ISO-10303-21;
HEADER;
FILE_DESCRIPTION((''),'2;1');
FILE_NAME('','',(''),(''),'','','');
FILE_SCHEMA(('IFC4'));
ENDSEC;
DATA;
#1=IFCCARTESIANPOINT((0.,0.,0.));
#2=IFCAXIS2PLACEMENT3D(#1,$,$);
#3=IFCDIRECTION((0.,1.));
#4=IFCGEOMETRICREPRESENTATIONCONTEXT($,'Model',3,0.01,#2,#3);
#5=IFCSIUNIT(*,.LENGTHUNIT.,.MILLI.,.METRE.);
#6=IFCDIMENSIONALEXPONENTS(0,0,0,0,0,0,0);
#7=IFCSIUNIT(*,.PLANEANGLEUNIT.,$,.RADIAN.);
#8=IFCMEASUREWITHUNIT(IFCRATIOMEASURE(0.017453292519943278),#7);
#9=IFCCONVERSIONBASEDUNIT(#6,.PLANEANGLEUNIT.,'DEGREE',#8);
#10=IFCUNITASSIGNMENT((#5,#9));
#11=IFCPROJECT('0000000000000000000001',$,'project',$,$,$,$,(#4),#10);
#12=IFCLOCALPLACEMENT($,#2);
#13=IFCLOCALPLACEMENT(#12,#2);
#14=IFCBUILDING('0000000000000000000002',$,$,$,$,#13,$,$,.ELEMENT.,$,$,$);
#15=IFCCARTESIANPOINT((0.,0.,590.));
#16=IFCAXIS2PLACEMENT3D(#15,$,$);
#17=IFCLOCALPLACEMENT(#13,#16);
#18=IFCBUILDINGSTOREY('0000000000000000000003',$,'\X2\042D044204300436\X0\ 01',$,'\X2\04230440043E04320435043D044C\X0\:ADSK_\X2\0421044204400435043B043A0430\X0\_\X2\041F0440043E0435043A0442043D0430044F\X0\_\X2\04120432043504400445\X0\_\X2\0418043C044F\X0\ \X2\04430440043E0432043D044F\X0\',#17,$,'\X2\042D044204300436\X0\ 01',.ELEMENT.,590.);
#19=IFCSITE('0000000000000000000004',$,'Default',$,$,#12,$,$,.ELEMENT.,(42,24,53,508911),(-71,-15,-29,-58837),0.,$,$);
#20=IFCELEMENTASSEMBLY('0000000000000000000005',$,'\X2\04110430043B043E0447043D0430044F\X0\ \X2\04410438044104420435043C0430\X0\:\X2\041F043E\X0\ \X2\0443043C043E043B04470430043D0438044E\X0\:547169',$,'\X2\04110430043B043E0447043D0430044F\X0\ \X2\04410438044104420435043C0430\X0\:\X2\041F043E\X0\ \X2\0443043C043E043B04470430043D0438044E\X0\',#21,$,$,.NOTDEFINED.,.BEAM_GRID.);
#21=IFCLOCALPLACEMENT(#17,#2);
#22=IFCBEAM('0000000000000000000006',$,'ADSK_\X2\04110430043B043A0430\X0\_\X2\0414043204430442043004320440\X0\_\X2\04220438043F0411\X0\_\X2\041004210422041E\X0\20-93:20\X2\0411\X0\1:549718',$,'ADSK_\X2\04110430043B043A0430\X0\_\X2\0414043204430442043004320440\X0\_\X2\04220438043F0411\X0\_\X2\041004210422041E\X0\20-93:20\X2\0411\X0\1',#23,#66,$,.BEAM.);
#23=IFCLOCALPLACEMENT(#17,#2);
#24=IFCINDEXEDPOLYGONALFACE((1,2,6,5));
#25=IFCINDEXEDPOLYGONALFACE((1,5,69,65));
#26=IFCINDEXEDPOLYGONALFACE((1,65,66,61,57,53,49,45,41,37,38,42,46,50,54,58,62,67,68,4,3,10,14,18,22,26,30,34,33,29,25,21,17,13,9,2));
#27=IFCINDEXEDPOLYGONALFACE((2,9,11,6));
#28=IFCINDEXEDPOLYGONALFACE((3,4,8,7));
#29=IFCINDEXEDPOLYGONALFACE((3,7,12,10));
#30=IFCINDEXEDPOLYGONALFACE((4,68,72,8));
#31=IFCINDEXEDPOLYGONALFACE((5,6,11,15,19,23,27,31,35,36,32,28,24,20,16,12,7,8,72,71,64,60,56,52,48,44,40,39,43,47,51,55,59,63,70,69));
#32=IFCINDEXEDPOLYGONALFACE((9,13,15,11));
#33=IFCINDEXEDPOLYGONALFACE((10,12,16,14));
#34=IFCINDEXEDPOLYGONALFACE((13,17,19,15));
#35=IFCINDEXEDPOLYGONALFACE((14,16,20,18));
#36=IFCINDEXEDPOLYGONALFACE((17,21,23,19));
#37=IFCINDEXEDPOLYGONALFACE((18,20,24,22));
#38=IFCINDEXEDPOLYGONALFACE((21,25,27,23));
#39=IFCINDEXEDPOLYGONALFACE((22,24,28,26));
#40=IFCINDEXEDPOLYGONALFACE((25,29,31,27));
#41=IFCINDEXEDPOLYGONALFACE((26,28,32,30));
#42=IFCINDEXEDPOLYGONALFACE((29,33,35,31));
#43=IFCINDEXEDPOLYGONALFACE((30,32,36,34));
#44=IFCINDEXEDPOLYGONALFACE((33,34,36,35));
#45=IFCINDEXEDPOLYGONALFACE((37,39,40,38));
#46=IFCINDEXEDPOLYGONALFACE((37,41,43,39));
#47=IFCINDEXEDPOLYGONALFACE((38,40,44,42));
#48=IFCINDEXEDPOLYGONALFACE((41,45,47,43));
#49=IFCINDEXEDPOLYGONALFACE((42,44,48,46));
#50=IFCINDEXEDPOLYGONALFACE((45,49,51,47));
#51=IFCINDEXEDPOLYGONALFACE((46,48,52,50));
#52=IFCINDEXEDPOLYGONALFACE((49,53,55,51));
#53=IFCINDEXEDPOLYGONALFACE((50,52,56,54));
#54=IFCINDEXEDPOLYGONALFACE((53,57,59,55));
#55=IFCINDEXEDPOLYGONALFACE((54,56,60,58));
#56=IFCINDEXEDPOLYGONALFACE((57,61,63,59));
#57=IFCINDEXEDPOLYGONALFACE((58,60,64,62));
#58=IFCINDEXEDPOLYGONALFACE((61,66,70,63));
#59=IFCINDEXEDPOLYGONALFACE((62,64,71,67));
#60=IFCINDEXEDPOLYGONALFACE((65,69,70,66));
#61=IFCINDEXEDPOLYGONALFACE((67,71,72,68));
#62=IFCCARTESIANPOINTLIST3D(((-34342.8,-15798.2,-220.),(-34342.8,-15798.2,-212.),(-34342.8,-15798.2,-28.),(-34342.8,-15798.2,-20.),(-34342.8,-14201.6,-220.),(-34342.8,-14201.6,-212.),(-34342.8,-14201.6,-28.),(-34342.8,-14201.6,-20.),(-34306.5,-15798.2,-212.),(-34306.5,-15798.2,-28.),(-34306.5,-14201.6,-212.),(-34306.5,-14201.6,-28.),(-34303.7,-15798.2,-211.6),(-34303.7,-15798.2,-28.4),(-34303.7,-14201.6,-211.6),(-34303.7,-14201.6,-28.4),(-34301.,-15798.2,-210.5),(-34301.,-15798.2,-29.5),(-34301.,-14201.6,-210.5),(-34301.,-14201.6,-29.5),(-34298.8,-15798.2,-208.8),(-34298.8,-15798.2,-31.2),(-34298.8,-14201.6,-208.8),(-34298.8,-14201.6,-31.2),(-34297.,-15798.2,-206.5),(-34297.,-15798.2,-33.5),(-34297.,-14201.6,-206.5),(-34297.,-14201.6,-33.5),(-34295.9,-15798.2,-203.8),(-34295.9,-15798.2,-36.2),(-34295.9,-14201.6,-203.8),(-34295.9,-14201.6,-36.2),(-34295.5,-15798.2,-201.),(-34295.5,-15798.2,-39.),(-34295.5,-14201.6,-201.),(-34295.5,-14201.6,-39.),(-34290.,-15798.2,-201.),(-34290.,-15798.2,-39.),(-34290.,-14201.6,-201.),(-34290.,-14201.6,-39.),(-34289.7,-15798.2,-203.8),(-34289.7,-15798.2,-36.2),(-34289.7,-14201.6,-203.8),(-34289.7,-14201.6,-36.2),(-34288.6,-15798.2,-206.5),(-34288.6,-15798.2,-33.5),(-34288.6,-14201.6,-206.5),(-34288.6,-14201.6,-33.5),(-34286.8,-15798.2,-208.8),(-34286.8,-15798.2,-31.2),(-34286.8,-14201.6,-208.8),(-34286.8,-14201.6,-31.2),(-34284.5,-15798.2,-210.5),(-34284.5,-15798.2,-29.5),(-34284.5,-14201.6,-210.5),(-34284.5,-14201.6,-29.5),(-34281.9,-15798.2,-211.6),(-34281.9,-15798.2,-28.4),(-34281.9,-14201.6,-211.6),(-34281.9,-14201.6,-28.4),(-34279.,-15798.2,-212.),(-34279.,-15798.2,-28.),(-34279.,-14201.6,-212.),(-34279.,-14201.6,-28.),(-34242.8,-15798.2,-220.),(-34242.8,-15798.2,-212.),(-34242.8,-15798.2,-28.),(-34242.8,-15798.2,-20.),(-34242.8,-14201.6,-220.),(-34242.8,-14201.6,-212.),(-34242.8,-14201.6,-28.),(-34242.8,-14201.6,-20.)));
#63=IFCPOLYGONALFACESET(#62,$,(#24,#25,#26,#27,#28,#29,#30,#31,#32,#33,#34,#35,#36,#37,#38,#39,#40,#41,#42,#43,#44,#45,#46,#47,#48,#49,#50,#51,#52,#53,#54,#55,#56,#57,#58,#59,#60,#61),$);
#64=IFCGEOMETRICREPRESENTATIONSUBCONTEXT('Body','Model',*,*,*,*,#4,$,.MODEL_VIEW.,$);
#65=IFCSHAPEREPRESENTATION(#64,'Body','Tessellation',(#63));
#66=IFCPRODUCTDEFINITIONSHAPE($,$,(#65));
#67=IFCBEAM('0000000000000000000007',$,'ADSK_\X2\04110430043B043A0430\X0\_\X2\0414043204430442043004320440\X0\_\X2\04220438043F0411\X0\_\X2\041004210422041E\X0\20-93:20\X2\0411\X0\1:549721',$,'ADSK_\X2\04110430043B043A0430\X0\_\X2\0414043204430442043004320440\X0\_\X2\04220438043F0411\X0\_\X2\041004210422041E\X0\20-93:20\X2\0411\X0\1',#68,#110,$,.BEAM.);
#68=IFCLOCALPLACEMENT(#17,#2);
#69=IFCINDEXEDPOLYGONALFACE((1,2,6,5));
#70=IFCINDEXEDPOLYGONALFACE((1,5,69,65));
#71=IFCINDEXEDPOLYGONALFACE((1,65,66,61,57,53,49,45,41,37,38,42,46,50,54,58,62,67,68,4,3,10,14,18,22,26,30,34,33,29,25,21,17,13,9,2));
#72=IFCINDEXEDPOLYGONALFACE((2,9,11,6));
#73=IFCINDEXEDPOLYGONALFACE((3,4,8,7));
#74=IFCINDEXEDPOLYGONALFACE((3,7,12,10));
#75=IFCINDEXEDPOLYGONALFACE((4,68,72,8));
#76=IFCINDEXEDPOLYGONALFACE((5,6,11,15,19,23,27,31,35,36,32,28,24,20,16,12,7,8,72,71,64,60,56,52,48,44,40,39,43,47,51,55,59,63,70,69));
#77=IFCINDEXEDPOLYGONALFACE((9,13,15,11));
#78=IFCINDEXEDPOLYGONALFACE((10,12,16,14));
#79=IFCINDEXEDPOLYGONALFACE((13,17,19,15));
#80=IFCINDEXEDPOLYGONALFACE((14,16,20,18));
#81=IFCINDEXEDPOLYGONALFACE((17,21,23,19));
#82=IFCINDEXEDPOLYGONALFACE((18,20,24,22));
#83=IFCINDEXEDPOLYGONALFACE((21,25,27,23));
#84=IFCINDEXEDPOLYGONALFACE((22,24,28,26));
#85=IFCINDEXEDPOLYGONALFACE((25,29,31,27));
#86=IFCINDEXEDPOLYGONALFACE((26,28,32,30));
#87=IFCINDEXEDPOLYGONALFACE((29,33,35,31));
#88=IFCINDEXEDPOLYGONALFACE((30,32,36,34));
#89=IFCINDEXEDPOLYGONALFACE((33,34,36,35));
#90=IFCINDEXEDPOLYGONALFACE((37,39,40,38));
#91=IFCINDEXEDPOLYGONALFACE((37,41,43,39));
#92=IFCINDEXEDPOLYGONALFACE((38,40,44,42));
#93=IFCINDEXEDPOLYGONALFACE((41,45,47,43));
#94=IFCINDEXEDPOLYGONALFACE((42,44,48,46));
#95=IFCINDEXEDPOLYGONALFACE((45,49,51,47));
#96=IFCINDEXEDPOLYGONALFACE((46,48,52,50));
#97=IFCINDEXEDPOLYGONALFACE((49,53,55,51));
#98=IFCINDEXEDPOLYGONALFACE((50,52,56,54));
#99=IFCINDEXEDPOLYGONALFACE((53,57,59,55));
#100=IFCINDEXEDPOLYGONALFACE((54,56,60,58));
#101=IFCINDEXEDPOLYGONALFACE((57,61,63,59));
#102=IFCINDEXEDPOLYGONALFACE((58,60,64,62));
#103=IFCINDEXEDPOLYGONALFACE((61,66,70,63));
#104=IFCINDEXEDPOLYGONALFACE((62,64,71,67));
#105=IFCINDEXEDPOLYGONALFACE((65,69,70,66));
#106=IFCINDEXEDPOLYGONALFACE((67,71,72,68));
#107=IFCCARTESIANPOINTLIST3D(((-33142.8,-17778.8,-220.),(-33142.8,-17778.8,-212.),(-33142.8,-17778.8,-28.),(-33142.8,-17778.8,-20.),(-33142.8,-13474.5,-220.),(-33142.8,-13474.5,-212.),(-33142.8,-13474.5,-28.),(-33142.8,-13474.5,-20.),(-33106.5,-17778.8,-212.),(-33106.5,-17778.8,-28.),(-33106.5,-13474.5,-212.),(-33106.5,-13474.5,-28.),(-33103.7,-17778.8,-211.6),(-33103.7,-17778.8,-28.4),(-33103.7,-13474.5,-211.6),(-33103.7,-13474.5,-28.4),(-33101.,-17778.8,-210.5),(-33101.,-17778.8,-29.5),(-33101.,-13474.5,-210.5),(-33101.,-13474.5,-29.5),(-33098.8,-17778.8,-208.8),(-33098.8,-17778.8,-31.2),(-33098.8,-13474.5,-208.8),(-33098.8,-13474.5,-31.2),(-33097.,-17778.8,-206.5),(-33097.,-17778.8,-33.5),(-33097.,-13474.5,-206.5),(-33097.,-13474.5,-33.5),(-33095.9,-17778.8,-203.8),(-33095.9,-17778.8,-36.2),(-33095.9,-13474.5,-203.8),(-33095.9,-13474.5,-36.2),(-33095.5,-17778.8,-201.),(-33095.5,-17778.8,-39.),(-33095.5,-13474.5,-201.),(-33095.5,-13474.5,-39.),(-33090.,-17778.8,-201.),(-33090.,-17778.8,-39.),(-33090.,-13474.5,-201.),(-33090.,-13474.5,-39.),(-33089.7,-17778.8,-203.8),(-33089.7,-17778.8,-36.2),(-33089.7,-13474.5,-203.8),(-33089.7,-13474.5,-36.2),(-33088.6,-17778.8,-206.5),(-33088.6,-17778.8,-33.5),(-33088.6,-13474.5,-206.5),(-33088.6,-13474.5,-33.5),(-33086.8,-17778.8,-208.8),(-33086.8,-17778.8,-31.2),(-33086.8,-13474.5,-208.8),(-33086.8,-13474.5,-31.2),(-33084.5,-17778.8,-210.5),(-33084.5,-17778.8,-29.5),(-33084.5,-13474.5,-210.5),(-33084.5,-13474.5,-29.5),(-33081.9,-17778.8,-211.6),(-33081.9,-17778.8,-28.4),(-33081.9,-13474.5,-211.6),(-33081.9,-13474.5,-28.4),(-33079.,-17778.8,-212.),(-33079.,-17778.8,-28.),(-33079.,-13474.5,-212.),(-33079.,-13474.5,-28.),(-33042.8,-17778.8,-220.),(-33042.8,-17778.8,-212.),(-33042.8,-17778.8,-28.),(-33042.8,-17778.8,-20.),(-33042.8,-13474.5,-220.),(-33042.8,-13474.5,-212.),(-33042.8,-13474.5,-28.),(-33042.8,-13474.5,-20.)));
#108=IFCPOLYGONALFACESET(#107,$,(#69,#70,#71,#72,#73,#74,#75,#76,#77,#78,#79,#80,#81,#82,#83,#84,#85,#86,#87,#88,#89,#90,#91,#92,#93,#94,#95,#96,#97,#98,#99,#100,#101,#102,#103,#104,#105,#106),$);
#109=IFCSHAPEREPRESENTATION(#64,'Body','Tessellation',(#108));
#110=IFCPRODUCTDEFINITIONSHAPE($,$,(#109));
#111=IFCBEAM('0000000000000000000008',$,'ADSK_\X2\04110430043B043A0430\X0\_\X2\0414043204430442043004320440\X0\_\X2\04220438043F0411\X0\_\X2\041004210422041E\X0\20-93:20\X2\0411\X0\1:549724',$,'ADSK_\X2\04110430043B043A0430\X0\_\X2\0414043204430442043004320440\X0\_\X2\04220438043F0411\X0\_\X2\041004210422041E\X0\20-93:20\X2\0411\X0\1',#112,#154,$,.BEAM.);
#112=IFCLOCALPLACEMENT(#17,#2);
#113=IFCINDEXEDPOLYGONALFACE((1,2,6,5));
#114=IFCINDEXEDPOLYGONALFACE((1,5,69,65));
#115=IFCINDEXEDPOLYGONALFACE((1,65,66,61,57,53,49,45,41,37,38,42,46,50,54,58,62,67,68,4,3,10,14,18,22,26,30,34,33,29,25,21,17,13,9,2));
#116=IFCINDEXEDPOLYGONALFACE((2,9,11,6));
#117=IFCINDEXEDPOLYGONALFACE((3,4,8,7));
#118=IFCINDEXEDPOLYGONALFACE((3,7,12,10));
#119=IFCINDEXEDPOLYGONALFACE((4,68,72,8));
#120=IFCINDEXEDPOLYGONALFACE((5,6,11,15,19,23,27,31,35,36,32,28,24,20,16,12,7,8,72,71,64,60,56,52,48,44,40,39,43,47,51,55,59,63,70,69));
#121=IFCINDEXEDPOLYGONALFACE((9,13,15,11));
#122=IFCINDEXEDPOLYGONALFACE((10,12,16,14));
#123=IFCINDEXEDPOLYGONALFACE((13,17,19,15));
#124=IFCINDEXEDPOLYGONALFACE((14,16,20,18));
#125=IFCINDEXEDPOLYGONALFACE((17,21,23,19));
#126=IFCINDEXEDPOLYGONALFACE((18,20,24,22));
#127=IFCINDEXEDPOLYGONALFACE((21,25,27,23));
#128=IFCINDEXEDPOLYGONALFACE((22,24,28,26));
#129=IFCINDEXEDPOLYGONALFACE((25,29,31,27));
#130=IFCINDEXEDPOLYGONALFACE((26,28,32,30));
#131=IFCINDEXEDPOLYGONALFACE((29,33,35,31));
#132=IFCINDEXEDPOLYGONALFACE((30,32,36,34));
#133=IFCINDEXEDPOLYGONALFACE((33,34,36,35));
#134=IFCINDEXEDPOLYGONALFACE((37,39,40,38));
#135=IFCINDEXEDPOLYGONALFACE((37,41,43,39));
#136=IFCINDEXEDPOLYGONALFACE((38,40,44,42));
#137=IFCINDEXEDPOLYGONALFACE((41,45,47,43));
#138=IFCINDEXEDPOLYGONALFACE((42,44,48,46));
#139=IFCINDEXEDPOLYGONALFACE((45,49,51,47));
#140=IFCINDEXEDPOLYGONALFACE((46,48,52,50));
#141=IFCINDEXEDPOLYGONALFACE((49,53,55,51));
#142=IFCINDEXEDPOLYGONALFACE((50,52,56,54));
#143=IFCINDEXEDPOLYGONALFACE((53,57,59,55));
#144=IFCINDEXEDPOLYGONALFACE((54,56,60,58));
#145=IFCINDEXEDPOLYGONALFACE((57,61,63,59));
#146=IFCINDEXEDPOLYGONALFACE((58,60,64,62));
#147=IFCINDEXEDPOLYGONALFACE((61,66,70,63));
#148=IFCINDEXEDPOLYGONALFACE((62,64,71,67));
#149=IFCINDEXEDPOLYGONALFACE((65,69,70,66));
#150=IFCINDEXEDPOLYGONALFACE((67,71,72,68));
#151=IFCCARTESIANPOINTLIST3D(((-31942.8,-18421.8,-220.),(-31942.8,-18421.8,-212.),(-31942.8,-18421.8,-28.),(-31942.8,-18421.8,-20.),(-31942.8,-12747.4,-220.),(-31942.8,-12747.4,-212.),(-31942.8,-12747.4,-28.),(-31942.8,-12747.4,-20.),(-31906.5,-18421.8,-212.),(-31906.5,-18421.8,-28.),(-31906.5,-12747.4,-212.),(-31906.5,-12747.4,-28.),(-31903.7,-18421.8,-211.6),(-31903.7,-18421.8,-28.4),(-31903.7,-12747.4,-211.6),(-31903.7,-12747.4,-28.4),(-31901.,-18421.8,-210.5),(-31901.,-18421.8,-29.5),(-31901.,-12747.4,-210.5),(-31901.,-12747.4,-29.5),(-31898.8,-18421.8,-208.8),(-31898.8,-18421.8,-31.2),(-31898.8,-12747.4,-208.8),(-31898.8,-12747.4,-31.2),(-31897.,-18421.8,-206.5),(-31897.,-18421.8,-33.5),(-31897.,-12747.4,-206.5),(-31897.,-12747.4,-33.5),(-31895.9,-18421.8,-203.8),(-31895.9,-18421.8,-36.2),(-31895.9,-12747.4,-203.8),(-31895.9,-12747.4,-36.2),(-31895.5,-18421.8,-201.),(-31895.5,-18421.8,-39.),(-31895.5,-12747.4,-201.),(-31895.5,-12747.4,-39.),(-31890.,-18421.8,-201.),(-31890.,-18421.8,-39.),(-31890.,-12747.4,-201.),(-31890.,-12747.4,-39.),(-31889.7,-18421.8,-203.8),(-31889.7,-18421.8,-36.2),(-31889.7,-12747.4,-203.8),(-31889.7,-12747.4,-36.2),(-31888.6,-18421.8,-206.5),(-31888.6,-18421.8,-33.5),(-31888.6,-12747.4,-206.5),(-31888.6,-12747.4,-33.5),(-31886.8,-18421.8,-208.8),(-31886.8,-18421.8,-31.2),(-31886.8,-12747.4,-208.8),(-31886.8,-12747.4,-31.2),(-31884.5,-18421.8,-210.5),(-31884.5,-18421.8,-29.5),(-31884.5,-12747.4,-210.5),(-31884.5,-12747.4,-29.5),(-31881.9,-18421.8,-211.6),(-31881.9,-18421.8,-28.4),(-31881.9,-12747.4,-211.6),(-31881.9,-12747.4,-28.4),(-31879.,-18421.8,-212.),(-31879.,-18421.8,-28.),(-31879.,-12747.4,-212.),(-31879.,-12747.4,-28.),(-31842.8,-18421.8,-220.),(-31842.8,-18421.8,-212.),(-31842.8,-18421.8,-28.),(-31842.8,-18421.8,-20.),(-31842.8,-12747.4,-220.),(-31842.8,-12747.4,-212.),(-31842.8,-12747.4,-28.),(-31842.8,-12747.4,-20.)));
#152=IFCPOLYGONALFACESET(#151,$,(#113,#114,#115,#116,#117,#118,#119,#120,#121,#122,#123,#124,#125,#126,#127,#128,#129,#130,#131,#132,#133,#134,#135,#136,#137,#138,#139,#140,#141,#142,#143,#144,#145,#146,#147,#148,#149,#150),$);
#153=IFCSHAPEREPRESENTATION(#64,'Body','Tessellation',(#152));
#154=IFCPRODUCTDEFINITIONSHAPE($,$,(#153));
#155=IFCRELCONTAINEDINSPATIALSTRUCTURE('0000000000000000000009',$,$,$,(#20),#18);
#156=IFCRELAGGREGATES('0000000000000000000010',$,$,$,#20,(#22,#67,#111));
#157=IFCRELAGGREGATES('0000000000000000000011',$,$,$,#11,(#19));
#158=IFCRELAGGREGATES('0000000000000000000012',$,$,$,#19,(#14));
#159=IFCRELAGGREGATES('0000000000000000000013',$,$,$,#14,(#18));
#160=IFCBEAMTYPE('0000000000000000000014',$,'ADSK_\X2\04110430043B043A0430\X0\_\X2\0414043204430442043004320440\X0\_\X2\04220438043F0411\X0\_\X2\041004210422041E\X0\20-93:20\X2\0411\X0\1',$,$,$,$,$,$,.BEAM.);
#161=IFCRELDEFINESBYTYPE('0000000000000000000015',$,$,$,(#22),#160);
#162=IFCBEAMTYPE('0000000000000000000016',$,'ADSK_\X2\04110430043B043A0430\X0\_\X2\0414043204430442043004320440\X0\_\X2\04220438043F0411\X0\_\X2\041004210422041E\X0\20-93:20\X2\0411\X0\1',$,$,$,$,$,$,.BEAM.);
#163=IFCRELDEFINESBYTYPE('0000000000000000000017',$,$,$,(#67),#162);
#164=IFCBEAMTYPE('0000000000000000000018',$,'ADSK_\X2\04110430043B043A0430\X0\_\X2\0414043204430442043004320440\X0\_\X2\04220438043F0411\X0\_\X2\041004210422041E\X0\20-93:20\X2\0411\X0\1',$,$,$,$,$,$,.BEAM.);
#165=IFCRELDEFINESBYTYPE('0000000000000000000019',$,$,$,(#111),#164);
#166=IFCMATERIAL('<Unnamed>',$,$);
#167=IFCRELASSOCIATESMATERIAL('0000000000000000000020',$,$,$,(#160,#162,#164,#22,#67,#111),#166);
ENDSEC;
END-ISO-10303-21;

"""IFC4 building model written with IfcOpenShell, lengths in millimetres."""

from ifc_helpers import new_model, entity, si_unit, converted_unit, direction, frame, frame_2d, origin, place, context, subcontext, project, spatial, polyline, circle_curve, parameter, trimmed, segment, composite_curve, i_section, outline, extrude, source, transform, mapped, material, material_profile, profile_set, profile_usage, type_object, type_shapes, element, aggregate, save


model = new_model("IFC4")

# Units and contexts
model_context = context("Model", 3, precision=0.01, world=origin(), true_north=direction((0.0, 1.0)))
body_context = subcontext(model_context, "Body", "Model", "MODEL_VIEW")
ifc_project = project(units=[si_unit("LENGTHUNIT", "METRE", prefix="MILLI"), converted_unit("PLANEANGLEUNIT", "DEGREE", entity("IfcRatioMeasure", 0.017453292519943278), si_unit("PLANEANGLEUNIT", "RADIAN"), dimensions=[0, 0, 0, 0, 0, 0, 0])], contexts=[model_context])

# Site, building, storey
site_placement = place(None, origin())
site = spatial("IfcSite", under=ifc_project, at=site_placement, Name="Default", CompositionType="ELEMENT", RefLatitude=(42, 24, 53, 508911), RefLongitude=(-71, -15, -29, -58837), RefElevation=0.0)
building_placement = place(site_placement, origin())
building = spatial("IfcBuilding", under=site, at=building_placement, CompositionType="ELEMENT")
storey_placement = place(building_placement, frame((0.0, 0.0, 590.0)))
storey = spatial("IfcBuildingStorey", under=building, at=storey_placement, Name="Этаж 01", ObjectType="Уровень:ADSK_Стрелка_Проектная_Вверх_Имя уровня", LongName="Этаж 01", CompositionType="ELEMENT", Elevation=590.0)

# Element assembly, beams
assembly_placement = place(storey_placement, origin())
assembly = element("IfcElementAssembly", 1, at=assembly_placement, inside=storey, Name="Балочная система:По умолчанию:547169", ObjectType="Балочная система:По умолчанию", AssemblyPlace="NOTDEFINED", PredefinedType="BEAM_GRID")
ifc_material_1 = material(Name="<Unnamed>")
ifc_material_profile = material_profile(ifc_material_1, outline(composite_curve([segment(polyline([(13.7, -192.0, 0.0), (50.0, -192.0, 0.0)]), True, "CONTINUOUS"), segment(polyline([(50.0, -192.0, 0.0), (50.0, -200.0, 0.0)]), True, "CONTINUOUS"), segment(polyline([(50.0, -200.0, 0.0), (-50.0, -200.0, 0.0)]), True, "CONTINUOUS"), segment(polyline([(-50.0, -200.0, 0.0), (-50.0, -192.0, 0.0)]), True, "CONTINUOUS"), segment(polyline([(-50.0, -192.0, 0.0), (-13.8, -192.0, 0.0)]), True, "CONTINUOUS"), segment(trimmed(circle_curve(frame((-13.8, -181.0, 0.0), z_axis=(0.0, 0.0, 1.0), x_axis=(-1.0, 0.0, 0.0)), 11.0), [parameter(90.0)], [parameter(180.0)], True, "PARAMETER"), True, "CONTINUOUS"), segment(polyline([(-2.8, -181.0, 0.0), (-2.8, -19.0, 0.0)]), True, "CONTINUOUS"), segment(trimmed(circle_curve(frame((-13.8, -19.0, 0.0), z_axis=(0.0, 0.0, 1.0), x_axis=(-1.0, 0.0, 0.0)), 11.0), [parameter(180.0)], [parameter(270.0)], True, "PARAMETER"), True, "CONTINUOUS"), segment(polyline([(-13.8, -8.0, 0.0), (-50.0, -8.0, 0.0)]), True, "CONTINUOUS"), segment(polyline([(-50.0, -8.0, 0.0), (-50.0, 0.0, 0.0)]), True, "CONTINUOUS"), segment(polyline([(-50.0, 0.0, 0.0), (50.0, 0.0, 0.0)]), True, "CONTINUOUS"), segment(polyline([(50.0, 0.0, 0.0), (50.0, -8.0, 0.0)]), True, "CONTINUOUS"), segment(polyline([(50.0, -8.0, 0.0), (13.7, -8.0, 0.0)]), True, "CONTINUOUS"), segment(trimmed(circle_curve(frame((13.7, -19.0, 0.0), z_axis=(0.0, 0.0, 1.0), x_axis=(-1.0, 0.0, 0.0)), 11.0), [parameter(270.0)], [parameter(0.0)], True, "PARAMETER"), True, "CONTINUOUS"), segment(polyline([(2.7, -19.0, 0.0), (2.7, -181.0, 0.0)]), True, "CONTINUOUS"), segment(trimmed(circle_curve(frame((13.7, -181.0, 0.0), z_axis=(0.0, 0.0, 1.0), x_axis=(-1.0, 0.0, 0.0)), 11.0), [parameter(0.0)], [parameter(90.0)], True, "PARAMETER"), True, "CONTINUOUS")], self_intersect=False), kind="CURVE"), Name="20Б1")
ifc_profile_set = profile_set([ifc_material_profile], Name="20Б1")
ifc_profile_usage_1 = profile_usage(ifc_profile_set, cardinal=8)
beam_type_1 = type_object("IfcBeamType", Name="ADSK_Балка_Двутавр_ТипБ_АСТО20-93:20Б1", PredefinedType="BEAM", material=ifc_profile_set)
shared_shape_1 = source(origin(), body_context, "Body", "SweptSolid", [
    extrude(i_section(OverallWidth=100.0, OverallDepth=200.0, WebThickness=5.5, FlangeThickness=8.0, FilletRadius=11.0, at=frame_2d((0.0, 0.0), x_axis=(0.0, 1.0))), frame((-798.3, 0.0, -100.0), z_axis=(1.0, 0.0, 0.0), x_axis=(0.0, 0.0, -1.0)), (0.0, 0.0, 1.0), 1596.5),
])
type_shapes(beam_type_1, [shared_shape_1])
beam_1_placement = place(assembly_placement, frame((-34292.8, -14999.9, -20.0), z_axis=(0.0, 0.0, 1.0), x_axis=(0.0, 1.0, 0.0)))
beam_1 = element("IfcBeam", 2, at=beam_1_placement, type_object=beam_type_1, material=ifc_profile_usage_1, Name="ADSK_Балка_Двутавр_ТипБ_АСТО20-93:20Б1:549718", ObjectType="ADSK_Балка_Двутавр_ТипБ_АСТО20-93:20Б1", PredefinedType="BEAM", context=body_context, shape_type="MappedRepresentation", body=[
    mapped(shared_shape_1, transform((0.0, 0.0, 0.0), scale=1.0)),
])
ifc_profile_usage_2 = profile_usage(ifc_profile_set, cardinal=8)
beam_type_2 = type_object("IfcBeamType", Name="ADSK_Балка_Двутавр_ТипБ_АСТО20-93:20Б1", PredefinedType="BEAM", material=ifc_profile_set)
shared_shape_2 = source(origin(), body_context, "Body", "SweptSolid", [
    extrude(i_section(OverallWidth=100.0, OverallDepth=200.0, WebThickness=5.5, FlangeThickness=8.0, FilletRadius=11.0, at=frame_2d((0.0, 0.0), x_axis=(0.0, 1.0))), frame((-2152.1, 0.0, -100.0), z_axis=(1.0, 0.0, 0.0), x_axis=(0.0, 0.0, -1.0)), (0.0, 0.0, 1.0), 4304.2),
])
type_shapes(beam_type_2, [shared_shape_2])
beam_2_placement = place(assembly_placement, frame((-33092.8, -15626.6, -20.0), z_axis=(0.0, 0.0, 1.0), x_axis=(0.0, 1.0, 0.0)))
beam_2 = element("IfcBeam", 3, at=beam_2_placement, type_object=beam_type_2, material=ifc_profile_usage_2, Name="ADSK_Балка_Двутавр_ТипБ_АСТО20-93:20Б1:549721", ObjectType="ADSK_Балка_Двутавр_ТипБ_АСТО20-93:20Б1", PredefinedType="BEAM", context=body_context, shape_type="MappedRepresentation", body=[
    mapped(shared_shape_2, transform((0.0, 0.0, 0.0), scale=1.0)),
])
ifc_profile_usage_3 = profile_usage(ifc_profile_set, cardinal=8)
beam_type_3 = type_object("IfcBeamType", Name="ADSK_Балка_Двутавр_ТипБ_АСТО20-93:20Б1", PredefinedType="BEAM", material=ifc_profile_set)
shared_shape_3 = source(origin(), body_context, "Body", "SweptSolid", [
    extrude(i_section(OverallWidth=100.0, OverallDepth=200.0, WebThickness=5.5, FlangeThickness=8.0, FilletRadius=11.0, at=frame_2d((0.0, 0.0), x_axis=(0.0, 1.0))), frame((-2837.2, 0.0, -100.0), z_axis=(1.0, 0.0, 0.0), x_axis=(0.0, 0.0, -1.0)), (0.0, 0.0, 1.0), 5674.4),
])
type_shapes(beam_type_3, [shared_shape_3])
beam_3_placement = place(assembly_placement, frame((-31892.8, -15584.6, -20.0), z_axis=(0.0, 0.0, 1.0), x_axis=(0.0, 1.0, 0.0)))
beam_3 = element("IfcBeam", 4, at=beam_3_placement, type_object=beam_type_3, material=ifc_profile_usage_3, Name="ADSK_Балка_Двутавр_ТипБ_АСТО20-93:20Б1:549724", ObjectType="ADSK_Балка_Двутавр_ТипБ_АСТО20-93:20Б1", PredefinedType="BEAM", context=body_context, shape_type="MappedRepresentation", body=[
    mapped(shared_shape_3, transform((0.0, 0.0, 0.0), scale=1.0)),
])
aggregate(assembly, [beam_1, beam_2, beam_3])

save(model, "model.ifc")
